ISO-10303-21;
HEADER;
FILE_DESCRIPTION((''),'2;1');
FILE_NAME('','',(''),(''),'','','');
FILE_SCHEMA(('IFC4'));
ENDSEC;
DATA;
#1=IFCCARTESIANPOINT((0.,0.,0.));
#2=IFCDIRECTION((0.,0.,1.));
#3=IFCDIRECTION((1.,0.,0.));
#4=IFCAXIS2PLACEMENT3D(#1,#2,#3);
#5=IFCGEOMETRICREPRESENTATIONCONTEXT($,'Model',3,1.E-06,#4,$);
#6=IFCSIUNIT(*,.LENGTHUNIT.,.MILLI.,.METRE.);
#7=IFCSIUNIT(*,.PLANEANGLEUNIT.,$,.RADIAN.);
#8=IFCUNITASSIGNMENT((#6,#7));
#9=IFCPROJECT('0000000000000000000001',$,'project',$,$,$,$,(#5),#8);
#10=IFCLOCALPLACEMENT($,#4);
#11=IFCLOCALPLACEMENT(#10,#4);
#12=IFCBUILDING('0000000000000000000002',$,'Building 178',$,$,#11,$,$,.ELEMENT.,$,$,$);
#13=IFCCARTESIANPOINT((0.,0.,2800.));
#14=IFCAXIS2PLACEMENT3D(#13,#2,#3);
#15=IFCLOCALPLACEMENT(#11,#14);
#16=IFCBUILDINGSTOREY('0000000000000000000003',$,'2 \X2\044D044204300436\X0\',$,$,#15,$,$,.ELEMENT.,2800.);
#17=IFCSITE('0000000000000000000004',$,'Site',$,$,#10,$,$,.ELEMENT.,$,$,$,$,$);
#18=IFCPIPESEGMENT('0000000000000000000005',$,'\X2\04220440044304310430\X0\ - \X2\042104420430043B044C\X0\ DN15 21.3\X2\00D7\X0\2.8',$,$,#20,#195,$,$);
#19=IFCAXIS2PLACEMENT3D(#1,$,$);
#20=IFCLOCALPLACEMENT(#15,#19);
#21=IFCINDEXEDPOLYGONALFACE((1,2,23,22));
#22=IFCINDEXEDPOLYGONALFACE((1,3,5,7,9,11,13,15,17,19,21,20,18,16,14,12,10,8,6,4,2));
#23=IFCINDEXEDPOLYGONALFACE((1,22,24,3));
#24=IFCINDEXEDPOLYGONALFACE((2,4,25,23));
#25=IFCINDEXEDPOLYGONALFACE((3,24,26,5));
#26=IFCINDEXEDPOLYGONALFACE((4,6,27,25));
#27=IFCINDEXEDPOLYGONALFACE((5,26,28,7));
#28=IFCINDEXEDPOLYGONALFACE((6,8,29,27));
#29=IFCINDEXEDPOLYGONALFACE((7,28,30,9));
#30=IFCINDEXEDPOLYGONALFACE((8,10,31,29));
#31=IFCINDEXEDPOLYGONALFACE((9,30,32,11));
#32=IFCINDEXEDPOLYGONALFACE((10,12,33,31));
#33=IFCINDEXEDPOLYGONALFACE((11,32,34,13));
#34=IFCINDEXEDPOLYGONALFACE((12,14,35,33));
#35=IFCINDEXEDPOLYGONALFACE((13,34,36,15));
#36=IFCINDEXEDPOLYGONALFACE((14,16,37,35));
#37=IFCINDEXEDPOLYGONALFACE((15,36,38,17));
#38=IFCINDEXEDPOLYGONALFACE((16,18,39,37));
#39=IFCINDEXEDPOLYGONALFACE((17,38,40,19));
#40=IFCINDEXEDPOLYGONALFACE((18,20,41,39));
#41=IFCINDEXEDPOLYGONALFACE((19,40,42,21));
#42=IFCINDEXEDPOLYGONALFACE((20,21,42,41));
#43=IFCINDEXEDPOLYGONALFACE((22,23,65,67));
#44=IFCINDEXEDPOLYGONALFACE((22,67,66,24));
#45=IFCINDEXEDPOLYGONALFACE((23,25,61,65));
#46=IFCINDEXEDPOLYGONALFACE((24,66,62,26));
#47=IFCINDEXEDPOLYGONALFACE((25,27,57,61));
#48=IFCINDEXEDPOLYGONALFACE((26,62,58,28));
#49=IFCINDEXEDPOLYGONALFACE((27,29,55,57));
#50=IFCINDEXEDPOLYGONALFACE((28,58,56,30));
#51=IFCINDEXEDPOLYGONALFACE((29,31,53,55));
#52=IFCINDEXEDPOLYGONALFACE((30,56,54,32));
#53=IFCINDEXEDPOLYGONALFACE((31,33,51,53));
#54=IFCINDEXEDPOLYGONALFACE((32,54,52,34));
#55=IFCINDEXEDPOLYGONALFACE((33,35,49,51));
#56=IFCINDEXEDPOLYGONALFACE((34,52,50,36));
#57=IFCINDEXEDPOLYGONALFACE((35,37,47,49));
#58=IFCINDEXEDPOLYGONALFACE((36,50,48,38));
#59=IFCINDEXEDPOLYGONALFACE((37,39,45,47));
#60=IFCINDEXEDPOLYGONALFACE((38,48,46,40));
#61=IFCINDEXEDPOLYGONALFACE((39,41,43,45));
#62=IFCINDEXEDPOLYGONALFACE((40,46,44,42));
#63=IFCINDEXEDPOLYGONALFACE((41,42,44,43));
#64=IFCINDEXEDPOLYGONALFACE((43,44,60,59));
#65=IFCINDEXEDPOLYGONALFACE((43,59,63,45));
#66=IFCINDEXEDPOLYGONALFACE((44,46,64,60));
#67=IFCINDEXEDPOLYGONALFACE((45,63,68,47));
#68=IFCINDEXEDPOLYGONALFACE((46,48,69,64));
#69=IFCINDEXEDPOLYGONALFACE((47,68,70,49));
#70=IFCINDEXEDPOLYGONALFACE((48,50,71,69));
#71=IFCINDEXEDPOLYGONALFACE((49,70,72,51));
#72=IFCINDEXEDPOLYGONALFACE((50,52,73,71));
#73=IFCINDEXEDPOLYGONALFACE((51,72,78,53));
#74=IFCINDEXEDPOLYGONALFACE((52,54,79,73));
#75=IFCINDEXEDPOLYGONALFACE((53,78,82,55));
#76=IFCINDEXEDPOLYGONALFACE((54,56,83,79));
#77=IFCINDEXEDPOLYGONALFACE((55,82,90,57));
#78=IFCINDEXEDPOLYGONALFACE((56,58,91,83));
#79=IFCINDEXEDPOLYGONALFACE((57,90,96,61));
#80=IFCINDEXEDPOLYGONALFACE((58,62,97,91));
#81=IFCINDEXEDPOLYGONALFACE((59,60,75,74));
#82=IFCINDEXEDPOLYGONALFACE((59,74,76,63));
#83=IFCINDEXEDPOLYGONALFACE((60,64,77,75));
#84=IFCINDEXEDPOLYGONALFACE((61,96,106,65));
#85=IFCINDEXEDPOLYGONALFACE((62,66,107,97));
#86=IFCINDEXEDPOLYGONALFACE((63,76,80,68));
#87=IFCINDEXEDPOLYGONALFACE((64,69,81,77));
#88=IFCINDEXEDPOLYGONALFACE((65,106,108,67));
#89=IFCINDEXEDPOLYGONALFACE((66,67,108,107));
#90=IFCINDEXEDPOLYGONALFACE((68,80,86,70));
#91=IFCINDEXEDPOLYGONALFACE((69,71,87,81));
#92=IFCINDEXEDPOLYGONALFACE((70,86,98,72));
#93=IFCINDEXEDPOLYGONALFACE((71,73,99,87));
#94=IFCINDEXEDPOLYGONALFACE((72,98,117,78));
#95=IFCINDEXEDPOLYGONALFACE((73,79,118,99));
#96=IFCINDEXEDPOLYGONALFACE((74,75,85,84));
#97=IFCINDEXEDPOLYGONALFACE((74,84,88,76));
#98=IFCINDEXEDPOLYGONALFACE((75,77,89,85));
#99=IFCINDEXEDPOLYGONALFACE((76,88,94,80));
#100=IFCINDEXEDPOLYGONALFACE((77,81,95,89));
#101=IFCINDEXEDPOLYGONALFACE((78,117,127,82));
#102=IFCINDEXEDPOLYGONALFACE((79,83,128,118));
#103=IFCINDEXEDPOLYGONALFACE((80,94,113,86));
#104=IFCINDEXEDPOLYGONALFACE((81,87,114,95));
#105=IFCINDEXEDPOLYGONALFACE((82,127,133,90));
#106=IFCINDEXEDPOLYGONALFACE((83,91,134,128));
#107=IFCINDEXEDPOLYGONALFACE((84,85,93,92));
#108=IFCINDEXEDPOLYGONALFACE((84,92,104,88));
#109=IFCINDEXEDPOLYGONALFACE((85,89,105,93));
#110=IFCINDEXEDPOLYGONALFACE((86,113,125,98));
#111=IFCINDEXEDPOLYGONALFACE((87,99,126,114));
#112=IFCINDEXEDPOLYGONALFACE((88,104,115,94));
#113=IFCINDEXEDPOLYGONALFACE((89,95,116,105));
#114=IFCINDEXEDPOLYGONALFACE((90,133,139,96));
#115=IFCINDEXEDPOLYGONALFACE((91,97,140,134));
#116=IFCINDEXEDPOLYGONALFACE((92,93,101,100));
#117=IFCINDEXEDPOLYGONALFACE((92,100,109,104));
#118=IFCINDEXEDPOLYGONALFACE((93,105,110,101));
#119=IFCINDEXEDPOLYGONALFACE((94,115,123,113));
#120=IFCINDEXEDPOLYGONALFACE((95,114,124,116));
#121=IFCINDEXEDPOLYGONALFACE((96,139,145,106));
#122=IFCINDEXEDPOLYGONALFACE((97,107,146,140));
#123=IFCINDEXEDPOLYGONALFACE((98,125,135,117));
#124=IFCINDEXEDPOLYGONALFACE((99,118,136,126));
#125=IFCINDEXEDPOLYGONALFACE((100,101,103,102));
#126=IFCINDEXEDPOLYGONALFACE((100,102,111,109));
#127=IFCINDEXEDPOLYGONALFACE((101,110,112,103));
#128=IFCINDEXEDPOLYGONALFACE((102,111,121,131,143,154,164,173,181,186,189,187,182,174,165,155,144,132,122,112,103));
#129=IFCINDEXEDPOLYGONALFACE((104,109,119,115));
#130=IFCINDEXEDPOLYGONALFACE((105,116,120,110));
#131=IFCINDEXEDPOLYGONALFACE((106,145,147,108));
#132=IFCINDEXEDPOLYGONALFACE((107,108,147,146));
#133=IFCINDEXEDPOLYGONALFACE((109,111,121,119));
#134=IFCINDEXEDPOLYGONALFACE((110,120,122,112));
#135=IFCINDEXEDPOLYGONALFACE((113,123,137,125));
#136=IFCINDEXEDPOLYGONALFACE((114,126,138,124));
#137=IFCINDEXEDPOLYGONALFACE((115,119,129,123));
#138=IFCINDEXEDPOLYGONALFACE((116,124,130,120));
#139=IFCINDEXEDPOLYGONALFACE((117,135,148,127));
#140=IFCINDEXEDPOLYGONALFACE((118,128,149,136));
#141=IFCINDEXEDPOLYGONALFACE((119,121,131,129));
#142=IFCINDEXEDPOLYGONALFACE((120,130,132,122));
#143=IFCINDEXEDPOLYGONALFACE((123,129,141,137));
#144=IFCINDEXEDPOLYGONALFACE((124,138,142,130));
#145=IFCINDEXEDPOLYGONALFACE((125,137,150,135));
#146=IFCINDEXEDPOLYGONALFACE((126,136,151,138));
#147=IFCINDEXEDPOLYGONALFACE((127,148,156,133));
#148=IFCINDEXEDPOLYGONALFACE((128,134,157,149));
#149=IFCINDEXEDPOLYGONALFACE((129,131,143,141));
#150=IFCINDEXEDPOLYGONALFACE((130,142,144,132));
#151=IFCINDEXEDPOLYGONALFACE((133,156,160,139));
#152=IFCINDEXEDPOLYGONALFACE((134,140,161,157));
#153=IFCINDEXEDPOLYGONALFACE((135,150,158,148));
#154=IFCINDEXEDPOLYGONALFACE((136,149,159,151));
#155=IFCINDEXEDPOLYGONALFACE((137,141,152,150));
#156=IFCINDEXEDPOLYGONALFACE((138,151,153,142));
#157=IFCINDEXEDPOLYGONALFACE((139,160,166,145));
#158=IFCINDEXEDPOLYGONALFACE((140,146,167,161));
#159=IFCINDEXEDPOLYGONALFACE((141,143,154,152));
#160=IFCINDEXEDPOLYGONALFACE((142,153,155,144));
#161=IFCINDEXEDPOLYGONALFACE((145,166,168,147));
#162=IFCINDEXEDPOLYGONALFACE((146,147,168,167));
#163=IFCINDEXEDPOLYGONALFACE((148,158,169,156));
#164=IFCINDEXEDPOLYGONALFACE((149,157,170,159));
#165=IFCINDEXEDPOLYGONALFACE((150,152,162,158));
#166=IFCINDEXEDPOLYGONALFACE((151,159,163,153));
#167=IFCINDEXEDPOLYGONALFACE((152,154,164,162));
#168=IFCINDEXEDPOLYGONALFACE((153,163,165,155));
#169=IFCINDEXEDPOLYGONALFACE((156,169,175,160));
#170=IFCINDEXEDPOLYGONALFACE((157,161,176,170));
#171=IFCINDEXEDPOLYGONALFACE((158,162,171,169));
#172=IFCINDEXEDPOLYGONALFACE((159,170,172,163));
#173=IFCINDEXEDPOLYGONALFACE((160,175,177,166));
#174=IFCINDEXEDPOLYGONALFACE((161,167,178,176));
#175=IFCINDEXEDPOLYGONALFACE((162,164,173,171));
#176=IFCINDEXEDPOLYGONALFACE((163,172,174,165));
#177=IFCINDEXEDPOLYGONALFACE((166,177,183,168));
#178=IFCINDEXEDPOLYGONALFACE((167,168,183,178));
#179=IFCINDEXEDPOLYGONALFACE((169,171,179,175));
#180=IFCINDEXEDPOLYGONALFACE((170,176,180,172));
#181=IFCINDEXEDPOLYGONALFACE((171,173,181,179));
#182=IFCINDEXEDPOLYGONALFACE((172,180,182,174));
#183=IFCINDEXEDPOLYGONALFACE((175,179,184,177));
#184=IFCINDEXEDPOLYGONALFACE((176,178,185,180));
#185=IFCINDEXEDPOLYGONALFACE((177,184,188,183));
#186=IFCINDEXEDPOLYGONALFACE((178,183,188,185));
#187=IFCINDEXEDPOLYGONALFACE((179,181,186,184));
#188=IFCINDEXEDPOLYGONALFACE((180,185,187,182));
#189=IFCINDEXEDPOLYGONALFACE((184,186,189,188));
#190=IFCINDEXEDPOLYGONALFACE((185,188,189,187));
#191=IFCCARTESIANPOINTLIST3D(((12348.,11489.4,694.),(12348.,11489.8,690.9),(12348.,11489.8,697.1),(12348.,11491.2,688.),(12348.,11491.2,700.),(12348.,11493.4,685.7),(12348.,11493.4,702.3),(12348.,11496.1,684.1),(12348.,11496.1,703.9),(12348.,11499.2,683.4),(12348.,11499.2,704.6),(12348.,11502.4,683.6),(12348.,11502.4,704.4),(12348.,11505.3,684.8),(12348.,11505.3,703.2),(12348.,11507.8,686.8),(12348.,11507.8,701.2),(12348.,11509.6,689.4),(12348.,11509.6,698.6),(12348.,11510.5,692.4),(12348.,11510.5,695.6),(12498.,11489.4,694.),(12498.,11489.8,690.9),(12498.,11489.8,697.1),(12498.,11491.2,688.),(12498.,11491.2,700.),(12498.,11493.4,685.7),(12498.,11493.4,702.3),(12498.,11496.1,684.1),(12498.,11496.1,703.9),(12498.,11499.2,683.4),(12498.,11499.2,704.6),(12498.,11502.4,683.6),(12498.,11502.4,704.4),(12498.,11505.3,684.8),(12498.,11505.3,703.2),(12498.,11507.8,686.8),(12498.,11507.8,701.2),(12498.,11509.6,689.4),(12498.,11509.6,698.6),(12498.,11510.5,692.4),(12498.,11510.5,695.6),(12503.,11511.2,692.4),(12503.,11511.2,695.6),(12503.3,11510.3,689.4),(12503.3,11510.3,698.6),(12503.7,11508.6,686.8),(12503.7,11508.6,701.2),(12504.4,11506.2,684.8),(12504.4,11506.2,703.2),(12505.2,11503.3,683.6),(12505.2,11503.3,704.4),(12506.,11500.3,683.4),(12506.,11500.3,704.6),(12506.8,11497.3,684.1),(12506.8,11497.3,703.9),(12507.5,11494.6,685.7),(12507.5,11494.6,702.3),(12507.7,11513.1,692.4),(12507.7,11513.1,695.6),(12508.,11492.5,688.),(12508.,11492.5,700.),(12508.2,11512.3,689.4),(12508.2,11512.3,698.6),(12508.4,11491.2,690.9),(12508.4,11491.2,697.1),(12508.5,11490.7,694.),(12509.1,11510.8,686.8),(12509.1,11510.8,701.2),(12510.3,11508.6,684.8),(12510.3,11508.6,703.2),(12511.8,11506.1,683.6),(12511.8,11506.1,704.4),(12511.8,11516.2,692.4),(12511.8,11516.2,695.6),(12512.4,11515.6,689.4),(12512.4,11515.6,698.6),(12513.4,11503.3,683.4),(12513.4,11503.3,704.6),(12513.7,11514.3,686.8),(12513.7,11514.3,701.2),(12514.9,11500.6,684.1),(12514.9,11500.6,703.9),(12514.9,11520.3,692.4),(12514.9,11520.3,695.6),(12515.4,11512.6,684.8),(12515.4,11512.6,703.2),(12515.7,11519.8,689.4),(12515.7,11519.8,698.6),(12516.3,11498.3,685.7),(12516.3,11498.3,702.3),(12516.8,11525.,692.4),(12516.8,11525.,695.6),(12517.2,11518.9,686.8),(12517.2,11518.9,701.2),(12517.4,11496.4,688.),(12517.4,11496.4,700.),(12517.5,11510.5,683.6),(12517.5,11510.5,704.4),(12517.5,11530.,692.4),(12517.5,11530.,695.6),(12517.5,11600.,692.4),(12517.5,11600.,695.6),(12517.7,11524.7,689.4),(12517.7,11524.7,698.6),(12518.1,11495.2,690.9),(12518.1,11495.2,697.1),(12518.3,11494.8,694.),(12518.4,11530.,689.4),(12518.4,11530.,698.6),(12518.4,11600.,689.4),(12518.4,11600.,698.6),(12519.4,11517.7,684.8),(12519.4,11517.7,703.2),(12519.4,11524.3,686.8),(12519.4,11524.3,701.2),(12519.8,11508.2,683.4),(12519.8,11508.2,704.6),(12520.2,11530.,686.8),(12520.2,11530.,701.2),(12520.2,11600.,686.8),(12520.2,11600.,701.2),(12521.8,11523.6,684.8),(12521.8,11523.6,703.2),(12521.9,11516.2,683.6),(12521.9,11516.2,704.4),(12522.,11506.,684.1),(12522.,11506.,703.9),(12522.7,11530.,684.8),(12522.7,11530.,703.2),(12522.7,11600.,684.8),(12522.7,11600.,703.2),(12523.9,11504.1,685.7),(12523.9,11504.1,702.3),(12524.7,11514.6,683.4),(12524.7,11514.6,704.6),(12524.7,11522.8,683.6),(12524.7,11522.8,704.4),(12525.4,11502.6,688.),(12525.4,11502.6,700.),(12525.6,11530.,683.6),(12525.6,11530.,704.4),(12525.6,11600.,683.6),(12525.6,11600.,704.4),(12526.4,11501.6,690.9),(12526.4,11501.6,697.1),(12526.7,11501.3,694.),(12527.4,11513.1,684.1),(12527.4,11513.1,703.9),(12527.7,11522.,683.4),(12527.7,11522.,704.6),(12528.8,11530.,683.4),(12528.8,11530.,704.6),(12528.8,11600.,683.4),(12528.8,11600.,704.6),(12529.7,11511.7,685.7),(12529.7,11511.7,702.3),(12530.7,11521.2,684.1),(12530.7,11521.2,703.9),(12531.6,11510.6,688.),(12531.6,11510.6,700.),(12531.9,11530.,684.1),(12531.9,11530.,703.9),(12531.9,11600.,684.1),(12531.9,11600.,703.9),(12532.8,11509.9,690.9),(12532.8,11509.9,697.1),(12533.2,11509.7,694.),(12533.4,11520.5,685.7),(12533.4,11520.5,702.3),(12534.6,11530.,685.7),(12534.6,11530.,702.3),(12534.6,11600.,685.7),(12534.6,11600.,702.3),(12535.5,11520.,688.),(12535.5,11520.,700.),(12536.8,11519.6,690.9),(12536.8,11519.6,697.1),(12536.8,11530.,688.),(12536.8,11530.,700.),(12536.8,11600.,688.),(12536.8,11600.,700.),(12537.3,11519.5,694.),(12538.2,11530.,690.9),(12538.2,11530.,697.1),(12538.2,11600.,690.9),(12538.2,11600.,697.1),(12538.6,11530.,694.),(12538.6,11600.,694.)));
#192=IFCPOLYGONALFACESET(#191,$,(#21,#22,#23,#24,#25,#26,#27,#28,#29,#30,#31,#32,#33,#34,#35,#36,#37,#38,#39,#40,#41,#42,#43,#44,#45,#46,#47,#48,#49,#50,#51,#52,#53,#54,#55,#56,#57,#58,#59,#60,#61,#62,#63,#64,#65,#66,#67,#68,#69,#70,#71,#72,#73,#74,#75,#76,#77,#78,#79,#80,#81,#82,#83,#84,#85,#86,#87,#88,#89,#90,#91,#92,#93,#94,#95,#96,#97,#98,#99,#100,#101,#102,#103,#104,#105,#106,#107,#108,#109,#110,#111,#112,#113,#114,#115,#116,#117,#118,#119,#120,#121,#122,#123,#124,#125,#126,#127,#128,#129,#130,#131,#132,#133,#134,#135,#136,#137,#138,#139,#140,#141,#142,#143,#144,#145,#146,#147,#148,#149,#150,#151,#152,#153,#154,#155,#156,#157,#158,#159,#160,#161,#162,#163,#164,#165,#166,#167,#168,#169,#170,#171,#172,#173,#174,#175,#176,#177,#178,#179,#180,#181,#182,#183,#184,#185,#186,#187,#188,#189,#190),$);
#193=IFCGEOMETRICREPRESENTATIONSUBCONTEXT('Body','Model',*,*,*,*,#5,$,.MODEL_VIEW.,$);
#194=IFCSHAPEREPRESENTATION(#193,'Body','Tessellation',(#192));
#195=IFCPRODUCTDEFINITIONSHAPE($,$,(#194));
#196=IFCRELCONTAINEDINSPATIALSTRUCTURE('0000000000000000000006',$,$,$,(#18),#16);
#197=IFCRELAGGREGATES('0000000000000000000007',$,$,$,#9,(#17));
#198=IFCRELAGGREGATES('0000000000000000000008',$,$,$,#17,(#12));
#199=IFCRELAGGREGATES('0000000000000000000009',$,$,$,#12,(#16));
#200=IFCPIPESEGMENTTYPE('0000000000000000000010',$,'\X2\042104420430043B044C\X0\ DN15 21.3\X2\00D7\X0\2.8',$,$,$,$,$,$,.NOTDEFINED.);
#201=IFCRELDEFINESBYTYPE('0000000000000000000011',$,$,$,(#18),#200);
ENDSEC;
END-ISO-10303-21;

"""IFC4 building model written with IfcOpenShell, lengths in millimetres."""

from ifc_helpers import new_model, entity, si_unit, frame, origin_with_axes, place, context, subcontext, project, spatial, source, transform, mapped, type_object, element, save


model = new_model("IFC4")

# Units and contexts
model_context = context("Model", 3, precision=1e-06, world=origin_with_axes())
body_context = subcontext(model_context, "Body", "Model", "MODEL_VIEW")
ifc_project = project(units=[si_unit("LENGTHUNIT", "METRE", prefix="MILLI"), si_unit("PLANEANGLEUNIT", "RADIAN")], contexts=[model_context])

# Site, building, storey
site_placement = place(None, origin_with_axes())
site = spatial("IfcSite", under=ifc_project, at=site_placement, Name="Site", CompositionType="ELEMENT")
building_placement = place(site_placement, origin_with_axes())
building = spatial("IfcBuilding", under=site, at=building_placement, Name="Building 178", CompositionType="ELEMENT")
storey_placement = place(building_placement, frame((0.0, 0.0, 2800.0), z_axis=(0.0, 0.0, 1.0), x_axis=(1.0, 0.0, 0.0)))
storey = spatial("IfcBuildingStorey", under=building, at=storey_placement, Name="2 этаж", CompositionType="ELEMENT", Elevation=2800.0)

# Pipe segment
pipe_segment_type = type_object("IfcPipeSegmentType", Name="Сталь DN15 21.3×2.8", PredefinedType="NOTDEFINED")
shared_shape_1 = source(origin_with_axes(), body_context, "Body", "AdvancedSweptSolid", [
    entity("IfcSweptDiskSolid", entity("IfcIndexedPolyCurve", entity("IfcCartesianPointList3D", [[0.0, 0.0, 0.0], [0.0, 0.0, -70.0], [8.8, 0.0, -91.2], [30.0, 0.0, -100.0], [180.0, 0.0, -100.0]]), [entity("IfcLineIndex", [1, 2]), entity("IfcArcIndex", [2, 3, 4]), entity("IfcLineIndex", [4, 5])]), 10.7),
])
for number, where, z_axis, x_axis, name in (
    (1, (12528.0, 11600.0, 694.0), (0.0, 1.0, 0.0), (-1.0, 0.0, 0.0), "Труба - Сталь DN15 21.3×2.8"),
):
    element("IfcPipeSegment", number, at=place(storey_placement, frame(where, z_axis=z_axis, x_axis=x_axis)), inside=storey, type_object=pipe_segment_type, Name=name, context=body_context, shape_type="MappedRepresentation", body=[
        mapped(shared_shape_1, transform((0.0, 0.0, 0.0), x_axis=(1.0, 0.0, 0.0), y_axis=(0.0, 1.0, 0.0), z_axis=(0.0, 0.0, 1.0), scale=1.0)),
    ])

save(model, "model.ifc")
